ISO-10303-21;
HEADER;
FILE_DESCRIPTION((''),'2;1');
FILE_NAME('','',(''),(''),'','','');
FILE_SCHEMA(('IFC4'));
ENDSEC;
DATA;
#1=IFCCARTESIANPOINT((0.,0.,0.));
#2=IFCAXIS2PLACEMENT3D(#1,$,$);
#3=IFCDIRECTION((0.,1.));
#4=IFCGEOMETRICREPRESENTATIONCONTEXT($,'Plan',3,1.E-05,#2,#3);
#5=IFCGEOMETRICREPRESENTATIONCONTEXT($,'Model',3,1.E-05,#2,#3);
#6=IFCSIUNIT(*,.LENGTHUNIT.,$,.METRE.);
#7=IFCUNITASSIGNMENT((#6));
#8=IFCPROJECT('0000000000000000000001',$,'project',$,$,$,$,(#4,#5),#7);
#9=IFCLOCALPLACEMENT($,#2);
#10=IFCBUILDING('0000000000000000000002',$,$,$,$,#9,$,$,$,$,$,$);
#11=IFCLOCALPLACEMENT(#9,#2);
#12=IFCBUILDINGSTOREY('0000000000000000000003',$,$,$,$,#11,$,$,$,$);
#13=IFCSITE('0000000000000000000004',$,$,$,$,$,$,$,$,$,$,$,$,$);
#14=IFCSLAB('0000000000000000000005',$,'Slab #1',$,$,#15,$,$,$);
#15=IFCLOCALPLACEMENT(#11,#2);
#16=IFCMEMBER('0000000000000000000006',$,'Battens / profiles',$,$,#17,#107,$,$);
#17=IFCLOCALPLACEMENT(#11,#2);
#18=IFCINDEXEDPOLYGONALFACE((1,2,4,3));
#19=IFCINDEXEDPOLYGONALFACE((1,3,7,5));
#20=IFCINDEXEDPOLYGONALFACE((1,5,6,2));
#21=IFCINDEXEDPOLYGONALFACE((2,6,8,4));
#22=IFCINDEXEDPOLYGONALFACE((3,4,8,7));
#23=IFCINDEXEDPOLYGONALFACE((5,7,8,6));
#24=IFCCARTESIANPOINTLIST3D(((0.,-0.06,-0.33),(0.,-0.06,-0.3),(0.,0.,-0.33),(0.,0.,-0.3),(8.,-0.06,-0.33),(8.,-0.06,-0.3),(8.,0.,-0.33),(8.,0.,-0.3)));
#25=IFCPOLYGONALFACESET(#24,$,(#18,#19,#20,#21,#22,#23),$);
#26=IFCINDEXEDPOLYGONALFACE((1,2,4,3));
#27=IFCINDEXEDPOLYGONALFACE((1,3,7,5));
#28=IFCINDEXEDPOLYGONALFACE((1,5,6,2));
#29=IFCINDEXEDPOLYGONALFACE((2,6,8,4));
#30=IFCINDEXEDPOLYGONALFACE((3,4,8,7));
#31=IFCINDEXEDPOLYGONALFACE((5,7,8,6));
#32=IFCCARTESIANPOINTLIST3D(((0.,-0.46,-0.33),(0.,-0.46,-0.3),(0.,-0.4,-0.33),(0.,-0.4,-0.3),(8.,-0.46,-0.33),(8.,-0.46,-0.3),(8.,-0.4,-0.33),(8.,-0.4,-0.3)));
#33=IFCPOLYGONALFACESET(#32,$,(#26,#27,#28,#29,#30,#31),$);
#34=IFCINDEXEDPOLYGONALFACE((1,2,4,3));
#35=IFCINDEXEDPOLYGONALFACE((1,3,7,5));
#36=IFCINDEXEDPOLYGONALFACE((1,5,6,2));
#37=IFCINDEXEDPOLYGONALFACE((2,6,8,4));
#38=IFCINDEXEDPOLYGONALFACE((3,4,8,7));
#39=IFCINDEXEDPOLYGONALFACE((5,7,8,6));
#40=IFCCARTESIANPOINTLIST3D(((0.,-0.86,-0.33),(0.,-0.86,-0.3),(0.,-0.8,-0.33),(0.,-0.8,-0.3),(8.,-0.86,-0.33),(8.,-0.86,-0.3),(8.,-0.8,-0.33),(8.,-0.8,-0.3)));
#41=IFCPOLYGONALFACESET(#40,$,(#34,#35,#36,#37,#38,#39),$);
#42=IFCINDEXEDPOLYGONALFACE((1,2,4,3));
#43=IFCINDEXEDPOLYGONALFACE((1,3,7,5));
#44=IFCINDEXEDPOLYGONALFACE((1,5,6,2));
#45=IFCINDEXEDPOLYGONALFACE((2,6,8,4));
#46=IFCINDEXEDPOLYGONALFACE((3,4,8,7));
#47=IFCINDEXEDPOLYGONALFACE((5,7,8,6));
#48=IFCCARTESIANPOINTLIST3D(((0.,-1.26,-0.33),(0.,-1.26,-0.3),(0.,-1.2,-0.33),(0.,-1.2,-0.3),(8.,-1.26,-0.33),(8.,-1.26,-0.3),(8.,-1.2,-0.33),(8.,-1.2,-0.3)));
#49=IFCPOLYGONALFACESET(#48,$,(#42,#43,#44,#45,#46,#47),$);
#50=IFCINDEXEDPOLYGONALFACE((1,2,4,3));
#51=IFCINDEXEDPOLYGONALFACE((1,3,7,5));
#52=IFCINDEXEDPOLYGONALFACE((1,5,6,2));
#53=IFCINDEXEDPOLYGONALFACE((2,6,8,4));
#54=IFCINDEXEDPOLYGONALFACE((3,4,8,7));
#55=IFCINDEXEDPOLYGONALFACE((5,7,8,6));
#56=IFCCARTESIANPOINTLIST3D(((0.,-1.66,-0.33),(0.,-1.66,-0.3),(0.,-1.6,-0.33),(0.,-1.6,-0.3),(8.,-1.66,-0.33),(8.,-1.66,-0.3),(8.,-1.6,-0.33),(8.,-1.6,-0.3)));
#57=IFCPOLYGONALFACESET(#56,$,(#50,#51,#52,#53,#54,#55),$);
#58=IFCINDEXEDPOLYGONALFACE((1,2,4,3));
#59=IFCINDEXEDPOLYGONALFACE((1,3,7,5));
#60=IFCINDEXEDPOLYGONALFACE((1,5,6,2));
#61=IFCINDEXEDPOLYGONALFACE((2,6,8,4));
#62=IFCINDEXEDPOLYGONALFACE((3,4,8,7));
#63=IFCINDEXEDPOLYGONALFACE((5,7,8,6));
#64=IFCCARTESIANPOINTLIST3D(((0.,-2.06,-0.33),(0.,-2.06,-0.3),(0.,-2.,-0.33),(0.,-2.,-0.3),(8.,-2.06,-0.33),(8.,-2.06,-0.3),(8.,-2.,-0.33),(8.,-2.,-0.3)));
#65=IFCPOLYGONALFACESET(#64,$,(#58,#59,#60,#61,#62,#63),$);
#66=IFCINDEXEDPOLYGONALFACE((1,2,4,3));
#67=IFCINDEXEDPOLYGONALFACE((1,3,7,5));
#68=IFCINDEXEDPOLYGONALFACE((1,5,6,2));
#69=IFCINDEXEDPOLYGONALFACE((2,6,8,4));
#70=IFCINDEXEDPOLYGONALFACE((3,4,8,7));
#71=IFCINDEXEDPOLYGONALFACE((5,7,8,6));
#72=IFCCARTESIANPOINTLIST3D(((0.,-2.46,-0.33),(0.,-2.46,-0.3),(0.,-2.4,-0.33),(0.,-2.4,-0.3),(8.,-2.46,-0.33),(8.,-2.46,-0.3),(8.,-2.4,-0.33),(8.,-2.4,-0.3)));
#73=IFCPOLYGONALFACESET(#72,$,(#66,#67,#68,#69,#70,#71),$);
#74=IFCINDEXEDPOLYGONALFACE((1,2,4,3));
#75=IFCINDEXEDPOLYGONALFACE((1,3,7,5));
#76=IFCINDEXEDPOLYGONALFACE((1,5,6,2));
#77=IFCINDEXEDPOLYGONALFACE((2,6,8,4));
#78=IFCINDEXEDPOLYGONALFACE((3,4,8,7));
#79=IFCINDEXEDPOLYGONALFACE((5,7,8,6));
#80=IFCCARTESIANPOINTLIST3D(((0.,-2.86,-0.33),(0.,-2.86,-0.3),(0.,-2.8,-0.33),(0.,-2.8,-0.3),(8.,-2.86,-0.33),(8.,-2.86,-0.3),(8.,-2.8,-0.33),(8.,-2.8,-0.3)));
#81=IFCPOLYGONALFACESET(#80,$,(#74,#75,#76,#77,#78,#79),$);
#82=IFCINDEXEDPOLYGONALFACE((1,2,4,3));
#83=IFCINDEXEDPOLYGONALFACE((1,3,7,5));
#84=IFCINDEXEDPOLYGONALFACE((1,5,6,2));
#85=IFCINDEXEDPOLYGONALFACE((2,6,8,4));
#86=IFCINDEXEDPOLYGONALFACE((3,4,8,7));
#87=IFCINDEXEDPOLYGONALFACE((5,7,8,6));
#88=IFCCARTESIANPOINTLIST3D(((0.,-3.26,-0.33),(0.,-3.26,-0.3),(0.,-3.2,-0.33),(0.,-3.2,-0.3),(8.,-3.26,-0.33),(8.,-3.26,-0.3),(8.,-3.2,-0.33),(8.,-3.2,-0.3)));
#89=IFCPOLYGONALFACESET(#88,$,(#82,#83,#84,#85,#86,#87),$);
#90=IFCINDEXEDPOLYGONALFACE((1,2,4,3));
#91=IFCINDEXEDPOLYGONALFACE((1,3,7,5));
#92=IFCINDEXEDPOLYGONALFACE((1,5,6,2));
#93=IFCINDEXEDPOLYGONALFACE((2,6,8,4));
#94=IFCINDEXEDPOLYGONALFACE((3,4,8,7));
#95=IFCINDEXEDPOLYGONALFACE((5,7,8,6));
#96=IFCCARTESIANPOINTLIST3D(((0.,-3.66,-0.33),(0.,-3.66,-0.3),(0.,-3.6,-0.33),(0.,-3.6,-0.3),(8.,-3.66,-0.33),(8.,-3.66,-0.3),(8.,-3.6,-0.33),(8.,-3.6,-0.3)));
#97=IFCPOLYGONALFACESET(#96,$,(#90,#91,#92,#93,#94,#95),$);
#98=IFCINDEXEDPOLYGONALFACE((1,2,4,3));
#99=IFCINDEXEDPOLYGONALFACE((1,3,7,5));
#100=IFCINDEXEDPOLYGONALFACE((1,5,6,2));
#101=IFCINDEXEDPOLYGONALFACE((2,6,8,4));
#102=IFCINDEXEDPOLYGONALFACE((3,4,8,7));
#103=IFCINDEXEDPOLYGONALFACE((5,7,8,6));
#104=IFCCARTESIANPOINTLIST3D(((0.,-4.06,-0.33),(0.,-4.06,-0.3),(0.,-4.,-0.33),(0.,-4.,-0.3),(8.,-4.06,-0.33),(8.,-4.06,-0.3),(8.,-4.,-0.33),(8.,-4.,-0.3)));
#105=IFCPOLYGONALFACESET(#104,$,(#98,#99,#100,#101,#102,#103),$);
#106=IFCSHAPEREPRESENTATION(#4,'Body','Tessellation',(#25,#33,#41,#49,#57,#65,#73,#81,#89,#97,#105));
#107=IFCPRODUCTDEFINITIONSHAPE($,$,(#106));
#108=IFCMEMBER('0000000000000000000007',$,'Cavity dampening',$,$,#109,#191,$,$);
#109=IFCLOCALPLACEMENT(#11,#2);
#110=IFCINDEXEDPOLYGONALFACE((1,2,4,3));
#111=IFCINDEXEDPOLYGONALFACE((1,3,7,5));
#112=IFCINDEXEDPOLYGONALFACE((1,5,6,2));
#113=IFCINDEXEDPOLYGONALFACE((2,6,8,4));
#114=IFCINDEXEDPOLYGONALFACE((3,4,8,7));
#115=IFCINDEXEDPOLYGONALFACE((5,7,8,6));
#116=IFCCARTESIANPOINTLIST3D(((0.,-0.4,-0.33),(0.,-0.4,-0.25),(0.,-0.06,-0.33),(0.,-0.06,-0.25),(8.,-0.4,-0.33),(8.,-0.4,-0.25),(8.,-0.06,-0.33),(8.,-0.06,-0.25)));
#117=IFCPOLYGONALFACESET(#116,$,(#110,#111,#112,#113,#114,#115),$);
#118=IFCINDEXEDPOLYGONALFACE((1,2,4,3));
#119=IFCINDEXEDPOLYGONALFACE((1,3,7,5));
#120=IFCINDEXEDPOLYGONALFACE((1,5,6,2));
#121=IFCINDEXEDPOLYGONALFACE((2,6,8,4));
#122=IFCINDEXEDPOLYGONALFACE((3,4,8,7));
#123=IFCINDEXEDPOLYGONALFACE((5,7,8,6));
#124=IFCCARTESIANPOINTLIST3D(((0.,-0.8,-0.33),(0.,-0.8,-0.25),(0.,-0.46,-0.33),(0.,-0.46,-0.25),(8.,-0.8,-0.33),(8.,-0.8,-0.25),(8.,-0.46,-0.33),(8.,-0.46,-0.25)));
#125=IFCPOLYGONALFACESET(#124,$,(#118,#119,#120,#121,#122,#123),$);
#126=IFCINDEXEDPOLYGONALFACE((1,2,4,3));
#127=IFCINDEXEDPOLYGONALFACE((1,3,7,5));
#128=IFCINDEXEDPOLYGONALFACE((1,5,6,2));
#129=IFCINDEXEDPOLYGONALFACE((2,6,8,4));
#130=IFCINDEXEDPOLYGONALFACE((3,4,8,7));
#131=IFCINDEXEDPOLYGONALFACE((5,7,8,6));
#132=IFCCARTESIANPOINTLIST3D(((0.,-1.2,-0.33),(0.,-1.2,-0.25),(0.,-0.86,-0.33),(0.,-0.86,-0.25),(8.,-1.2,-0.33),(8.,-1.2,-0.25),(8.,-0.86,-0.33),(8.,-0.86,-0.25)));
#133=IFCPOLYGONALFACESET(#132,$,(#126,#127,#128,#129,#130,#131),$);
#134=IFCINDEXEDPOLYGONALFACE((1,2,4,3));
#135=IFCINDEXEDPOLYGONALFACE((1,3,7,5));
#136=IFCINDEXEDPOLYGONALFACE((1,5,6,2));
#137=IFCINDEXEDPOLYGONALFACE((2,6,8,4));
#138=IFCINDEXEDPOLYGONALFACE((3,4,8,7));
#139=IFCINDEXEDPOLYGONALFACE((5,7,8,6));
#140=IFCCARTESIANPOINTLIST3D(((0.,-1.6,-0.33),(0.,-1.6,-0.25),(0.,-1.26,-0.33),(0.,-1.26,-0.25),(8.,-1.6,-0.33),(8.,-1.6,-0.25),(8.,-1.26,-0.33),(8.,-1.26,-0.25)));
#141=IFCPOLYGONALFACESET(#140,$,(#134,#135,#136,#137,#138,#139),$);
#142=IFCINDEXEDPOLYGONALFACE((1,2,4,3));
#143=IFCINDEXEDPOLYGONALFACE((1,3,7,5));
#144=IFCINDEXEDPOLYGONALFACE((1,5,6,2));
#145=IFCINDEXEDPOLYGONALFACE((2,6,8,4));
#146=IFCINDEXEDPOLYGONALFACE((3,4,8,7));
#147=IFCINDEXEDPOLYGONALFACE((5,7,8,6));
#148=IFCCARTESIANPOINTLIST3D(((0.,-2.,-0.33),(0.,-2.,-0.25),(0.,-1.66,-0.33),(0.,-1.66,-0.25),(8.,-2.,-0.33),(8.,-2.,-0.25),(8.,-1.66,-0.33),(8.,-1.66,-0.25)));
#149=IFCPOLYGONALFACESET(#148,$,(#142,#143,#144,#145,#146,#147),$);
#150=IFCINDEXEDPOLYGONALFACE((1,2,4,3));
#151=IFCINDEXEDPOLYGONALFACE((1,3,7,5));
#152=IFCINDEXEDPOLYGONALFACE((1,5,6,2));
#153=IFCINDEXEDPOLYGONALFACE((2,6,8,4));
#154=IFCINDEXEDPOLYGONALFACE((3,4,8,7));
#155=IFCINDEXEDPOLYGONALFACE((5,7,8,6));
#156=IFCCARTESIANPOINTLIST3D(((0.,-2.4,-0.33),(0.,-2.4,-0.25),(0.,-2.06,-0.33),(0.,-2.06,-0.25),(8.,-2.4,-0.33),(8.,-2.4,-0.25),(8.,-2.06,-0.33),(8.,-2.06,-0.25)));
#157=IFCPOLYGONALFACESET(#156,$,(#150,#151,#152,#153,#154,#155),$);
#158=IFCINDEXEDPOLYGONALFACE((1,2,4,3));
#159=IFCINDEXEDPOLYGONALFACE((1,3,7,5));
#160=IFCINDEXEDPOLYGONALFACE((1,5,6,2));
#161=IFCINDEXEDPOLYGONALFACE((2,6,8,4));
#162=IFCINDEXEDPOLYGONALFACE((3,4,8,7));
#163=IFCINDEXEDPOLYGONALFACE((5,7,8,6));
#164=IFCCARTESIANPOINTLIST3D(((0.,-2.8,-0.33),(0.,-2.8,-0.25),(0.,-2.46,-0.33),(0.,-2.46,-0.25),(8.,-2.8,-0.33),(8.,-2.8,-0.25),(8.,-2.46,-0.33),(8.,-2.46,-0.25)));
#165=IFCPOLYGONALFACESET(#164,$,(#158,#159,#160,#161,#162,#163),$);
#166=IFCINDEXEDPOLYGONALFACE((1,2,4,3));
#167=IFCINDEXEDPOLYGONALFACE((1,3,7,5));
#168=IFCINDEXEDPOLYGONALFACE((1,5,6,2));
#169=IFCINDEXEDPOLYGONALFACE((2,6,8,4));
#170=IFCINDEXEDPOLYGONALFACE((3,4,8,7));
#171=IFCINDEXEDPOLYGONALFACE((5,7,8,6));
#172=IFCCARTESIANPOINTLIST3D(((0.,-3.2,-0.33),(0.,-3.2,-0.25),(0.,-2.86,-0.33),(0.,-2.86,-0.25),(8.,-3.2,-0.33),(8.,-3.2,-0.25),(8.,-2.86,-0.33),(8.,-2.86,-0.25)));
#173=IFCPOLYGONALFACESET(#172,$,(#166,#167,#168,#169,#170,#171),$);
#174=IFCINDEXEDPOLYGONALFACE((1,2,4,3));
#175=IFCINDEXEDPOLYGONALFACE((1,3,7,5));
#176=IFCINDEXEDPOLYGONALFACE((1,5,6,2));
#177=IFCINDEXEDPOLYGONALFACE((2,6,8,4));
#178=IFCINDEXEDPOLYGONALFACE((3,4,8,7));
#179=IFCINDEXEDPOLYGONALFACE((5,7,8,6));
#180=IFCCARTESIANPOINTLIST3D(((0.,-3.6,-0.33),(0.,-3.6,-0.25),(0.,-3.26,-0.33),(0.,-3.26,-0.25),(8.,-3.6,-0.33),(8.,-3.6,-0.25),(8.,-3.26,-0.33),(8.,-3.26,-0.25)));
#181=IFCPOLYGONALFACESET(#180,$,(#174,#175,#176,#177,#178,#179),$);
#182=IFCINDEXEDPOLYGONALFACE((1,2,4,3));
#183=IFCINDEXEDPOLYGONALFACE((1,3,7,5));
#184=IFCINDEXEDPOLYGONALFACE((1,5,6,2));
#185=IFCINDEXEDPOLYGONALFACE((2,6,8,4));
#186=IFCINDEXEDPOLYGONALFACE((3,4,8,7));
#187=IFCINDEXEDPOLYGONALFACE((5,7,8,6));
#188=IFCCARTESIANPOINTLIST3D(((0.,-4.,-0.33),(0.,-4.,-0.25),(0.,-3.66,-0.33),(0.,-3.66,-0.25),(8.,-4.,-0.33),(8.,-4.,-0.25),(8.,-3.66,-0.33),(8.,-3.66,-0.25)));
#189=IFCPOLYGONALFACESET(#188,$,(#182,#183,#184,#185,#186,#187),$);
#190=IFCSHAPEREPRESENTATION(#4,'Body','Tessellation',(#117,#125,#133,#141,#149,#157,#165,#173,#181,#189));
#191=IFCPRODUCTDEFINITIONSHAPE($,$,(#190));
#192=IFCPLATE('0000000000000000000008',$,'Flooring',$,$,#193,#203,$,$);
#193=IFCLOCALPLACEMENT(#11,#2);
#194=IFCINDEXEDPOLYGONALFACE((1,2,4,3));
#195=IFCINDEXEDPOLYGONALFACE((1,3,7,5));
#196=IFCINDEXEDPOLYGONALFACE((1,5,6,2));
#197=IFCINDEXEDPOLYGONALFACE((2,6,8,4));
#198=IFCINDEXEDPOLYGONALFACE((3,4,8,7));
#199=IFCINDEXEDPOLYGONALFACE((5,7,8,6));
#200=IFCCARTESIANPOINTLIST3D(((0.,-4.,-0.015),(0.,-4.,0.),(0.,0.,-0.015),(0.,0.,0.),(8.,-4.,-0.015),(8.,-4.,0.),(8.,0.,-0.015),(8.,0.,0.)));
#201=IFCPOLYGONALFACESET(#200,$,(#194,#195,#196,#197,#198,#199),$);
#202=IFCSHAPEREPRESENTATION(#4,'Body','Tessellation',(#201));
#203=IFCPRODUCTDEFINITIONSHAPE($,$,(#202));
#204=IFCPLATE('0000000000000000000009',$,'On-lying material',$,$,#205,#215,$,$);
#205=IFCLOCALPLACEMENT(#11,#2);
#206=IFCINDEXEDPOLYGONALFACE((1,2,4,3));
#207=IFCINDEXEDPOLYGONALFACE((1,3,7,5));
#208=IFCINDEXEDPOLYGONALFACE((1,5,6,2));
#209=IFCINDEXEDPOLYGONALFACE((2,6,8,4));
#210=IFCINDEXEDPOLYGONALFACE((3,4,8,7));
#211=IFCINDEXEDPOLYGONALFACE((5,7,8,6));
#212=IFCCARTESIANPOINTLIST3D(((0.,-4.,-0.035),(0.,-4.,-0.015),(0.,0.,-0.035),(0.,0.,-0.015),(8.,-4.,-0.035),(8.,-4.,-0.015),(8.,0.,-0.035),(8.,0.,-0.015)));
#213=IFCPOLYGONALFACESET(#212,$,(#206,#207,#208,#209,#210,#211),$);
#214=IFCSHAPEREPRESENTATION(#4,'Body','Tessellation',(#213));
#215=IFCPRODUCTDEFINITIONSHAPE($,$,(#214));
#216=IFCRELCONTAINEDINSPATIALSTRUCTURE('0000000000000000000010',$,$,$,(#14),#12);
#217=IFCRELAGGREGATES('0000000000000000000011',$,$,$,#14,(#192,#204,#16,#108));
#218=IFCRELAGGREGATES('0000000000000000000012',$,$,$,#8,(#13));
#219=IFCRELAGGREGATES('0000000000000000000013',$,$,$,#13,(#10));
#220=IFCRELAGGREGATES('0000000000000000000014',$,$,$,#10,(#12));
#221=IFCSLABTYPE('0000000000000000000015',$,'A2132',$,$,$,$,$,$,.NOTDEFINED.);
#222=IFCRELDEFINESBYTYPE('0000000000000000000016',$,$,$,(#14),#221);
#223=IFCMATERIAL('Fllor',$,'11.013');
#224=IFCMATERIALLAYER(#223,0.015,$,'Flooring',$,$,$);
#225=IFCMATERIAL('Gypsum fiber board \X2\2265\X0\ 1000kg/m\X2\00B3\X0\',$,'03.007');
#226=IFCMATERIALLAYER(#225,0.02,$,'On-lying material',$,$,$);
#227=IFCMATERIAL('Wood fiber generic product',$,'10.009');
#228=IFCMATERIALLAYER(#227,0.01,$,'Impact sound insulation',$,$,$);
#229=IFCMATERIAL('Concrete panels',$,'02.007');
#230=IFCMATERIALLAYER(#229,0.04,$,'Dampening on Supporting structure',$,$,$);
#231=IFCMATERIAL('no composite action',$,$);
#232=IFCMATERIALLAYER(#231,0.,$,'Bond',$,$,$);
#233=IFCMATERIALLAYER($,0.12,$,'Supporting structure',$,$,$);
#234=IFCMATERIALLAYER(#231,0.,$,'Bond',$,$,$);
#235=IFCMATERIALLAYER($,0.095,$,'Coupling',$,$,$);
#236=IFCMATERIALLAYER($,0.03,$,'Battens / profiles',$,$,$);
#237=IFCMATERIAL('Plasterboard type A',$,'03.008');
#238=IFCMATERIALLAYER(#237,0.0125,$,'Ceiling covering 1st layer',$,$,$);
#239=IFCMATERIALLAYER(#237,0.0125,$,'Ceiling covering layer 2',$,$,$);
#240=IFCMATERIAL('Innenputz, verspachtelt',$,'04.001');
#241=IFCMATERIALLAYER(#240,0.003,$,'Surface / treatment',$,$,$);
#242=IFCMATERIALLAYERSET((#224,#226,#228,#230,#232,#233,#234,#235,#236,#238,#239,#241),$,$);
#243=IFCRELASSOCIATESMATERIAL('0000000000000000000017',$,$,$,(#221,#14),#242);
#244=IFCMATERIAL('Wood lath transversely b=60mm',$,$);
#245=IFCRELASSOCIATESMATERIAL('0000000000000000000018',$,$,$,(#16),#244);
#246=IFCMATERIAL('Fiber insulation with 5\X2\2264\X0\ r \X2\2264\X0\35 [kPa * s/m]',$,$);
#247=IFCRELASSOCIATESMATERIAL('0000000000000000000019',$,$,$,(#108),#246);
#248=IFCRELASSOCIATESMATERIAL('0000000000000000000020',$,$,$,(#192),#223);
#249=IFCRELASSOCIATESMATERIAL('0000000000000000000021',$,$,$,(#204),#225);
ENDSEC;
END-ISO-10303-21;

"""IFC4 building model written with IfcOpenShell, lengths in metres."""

from ifc_helpers import new_model, si_unit, direction, frame, frame_2d, origin, origin_with_axes, place, context, project, spatial, rectangle, extrude, material, layer, layer_set, type_object, element, aggregate, save


model = new_model("IFC4")

# Units and contexts
plan_context = context("Plan", 3, precision=1e-05, world=origin(), true_north=direction((0.0, 1.0)))
model_context = context("Model", 3, precision=1e-05, world=origin(), true_north=direction((0.0, 1.0)))
ifc_project = project(units=[si_unit("LENGTHUNIT", "METRE")], contexts=[plan_context, model_context])

# Site, building, storey
site = spatial("IfcSite", under=ifc_project)
building_placement = place(None, origin())
building = spatial("IfcBuilding", under=site, at=building_placement)
storey_placement = place(building_placement, origin())
storey = spatial("IfcBuildingStorey", under=building, at=storey_placement)

# Slab, members, plates
ifc_material_1 = material(Name="Fllor", Category="11.013")
ifc_layer_1 = layer(ifc_material_1, 0.015, Name="Flooring")
ifc_material_2 = material(Name="Gypsum fiber board ≥ 1000kg/m³", Category="03.007")
ifc_layer_2 = layer(ifc_material_2, 0.02, Name="On-lying material")
ifc_material_3 = material(Name="Wood fiber generic product", Category="10.009")
ifc_layer_3 = layer(ifc_material_3, 0.01, Name="Impact sound insulation")
ifc_material_4 = material(Name="Concrete panels", Category="02.007")
ifc_layer_4 = layer(ifc_material_4, 0.04, Name="Dampening on Supporting structure")
ifc_material_5 = material(Name="no composite action")
ifc_layer_5 = layer(ifc_material_5, 0.0, Name="Bond")
ifc_layer_6 = layer(None, 0.12, Name="Supporting structure")
ifc_layer_7 = layer(ifc_material_5, 0.0, Name="Bond")
ifc_layer_8 = layer(None, 0.095, Name="Coupling")
ifc_layer_9 = layer(None, 0.03, Name="Battens / profiles")
ifc_material_6 = material(Name="Plasterboard type A", Category="03.008")
ifc_layer_10 = layer(ifc_material_6, 0.0125, Name="Ceiling covering 1st layer")
ifc_layer_11 = layer(ifc_material_6, 0.0125, Name="Ceiling covering layer 2")
ifc_material_7 = material(Name="Innenputz, verspachtelt", Category="04.001")
ifc_layer_12 = layer(ifc_material_7, 0.003, Name="Surface / treatment")
ifc_layer_set = layer_set([ifc_layer_1, ifc_layer_2, ifc_layer_3, ifc_layer_4, ifc_layer_5, ifc_layer_6, ifc_layer_7, ifc_layer_8, ifc_layer_9, ifc_layer_10, ifc_layer_11, ifc_layer_12])
slab_type = type_object("IfcSlabType", Name="A2132", PredefinedType="NOTDEFINED", material=ifc_layer_set)
slab_placement = place(None, frame((0.0, 0.0, 0.0), z_axis=(0.0, 0.0, -1.0), x_axis=(1.0, 0.0, 0.0)))
slab = element("IfcSlab", 1, at=slab_placement, inside=storey, type_object=slab_type, material=ifc_layer_set, Name="Slab #1")
ifc_material_8 = material(Name="Wood lath transversely b=60mm")
member_1_placement = place(slab_placement, origin())
member_1 = element("IfcMember", 2, at=member_1_placement, material=ifc_material_8, Name="Battens / profiles", context=plan_context, shape_type="SweptSolid", body=[
    extrude(rectangle(XDim=0.06, YDim=0.03, at=frame_2d((0.03, 0.015), x_axis=(1.0, 0.0))), frame((0.0, 0.0, 0.3), z_axis=(1.0, 0.0, 0.0), x_axis=(0.0, 1.0, 0.0)), (0.0, 0.0, 1.0), 8.0),
    extrude(rectangle(XDim=0.06, YDim=0.03, at=frame_2d((0.03, 0.015), x_axis=(1.0, 0.0))), frame((0.0, 0.4, 0.3), z_axis=(1.0, 0.0, 0.0), x_axis=(0.0, 1.0, 0.0)), (0.0, 0.0, 1.0), 8.0),
    extrude(rectangle(XDim=0.06, YDim=0.03, at=frame_2d((0.03, 0.015), x_axis=(1.0, 0.0))), frame((0.0, 0.8, 0.3), z_axis=(1.0, 0.0, 0.0), x_axis=(0.0, 1.0, 0.0)), (0.0, 0.0, 1.0), 8.0),
    extrude(rectangle(XDim=0.06, YDim=0.03, at=frame_2d((0.03, 0.015), x_axis=(1.0, 0.0))), frame((0.0, 1.2, 0.3), z_axis=(1.0, 0.0, 0.0), x_axis=(0.0, 1.0, 0.0)), (0.0, 0.0, 1.0), 8.0),
    extrude(rectangle(XDim=0.06, YDim=0.03, at=frame_2d((0.03, 0.015), x_axis=(1.0, 0.0))), frame((0.0, 1.6, 0.3), z_axis=(1.0, 0.0, 0.0), x_axis=(0.0, 1.0, 0.0)), (0.0, 0.0, 1.0), 8.0),
    extrude(rectangle(XDim=0.06, YDim=0.03, at=frame_2d((0.03, 0.015), x_axis=(1.0, 0.0))), frame((0.0, 2.0, 0.3), z_axis=(1.0, 0.0, 0.0), x_axis=(0.0, 1.0, 0.0)), (0.0, 0.0, 1.0), 8.0),
    extrude(rectangle(XDim=0.06, YDim=0.03, at=frame_2d((0.03, 0.015), x_axis=(1.0, 0.0))), frame((0.0, 2.4, 0.3), z_axis=(1.0, 0.0, 0.0), x_axis=(0.0, 1.0, 0.0)), (0.0, 0.0, 1.0), 8.0),
    extrude(rectangle(XDim=0.06, YDim=0.03, at=frame_2d((0.03, 0.015), x_axis=(1.0, 0.0))), frame((0.0, 2.8, 0.3), z_axis=(1.0, 0.0, 0.0), x_axis=(0.0, 1.0, 0.0)), (0.0, 0.0, 1.0), 8.0),
    extrude(rectangle(XDim=0.06, YDim=0.03, at=frame_2d((0.03, 0.015), x_axis=(1.0, 0.0))), frame((0.0, 3.2, 0.3), z_axis=(1.0, 0.0, 0.0), x_axis=(0.0, 1.0, 0.0)), (0.0, 0.0, 1.0), 8.0),
    extrude(rectangle(XDim=0.06, YDim=0.03, at=frame_2d((0.03, 0.015), x_axis=(1.0, 0.0))), frame((0.0, 3.6, 0.3), z_axis=(1.0, 0.0, 0.0), x_axis=(0.0, 1.0, 0.0)), (0.0, 0.0, 1.0), 8.0),
    extrude(rectangle(XDim=0.06, YDim=0.03, at=frame_2d((0.03, 0.015), x_axis=(1.0, 0.0))), frame((0.0, 4.0, 0.3), z_axis=(1.0, 0.0, 0.0), x_axis=(0.0, 1.0, 0.0)), (0.0, 0.0, 1.0), 8.0),
])
ifc_material_9 = material(Name="Fiber insulation with 5≤ r ≤35 [kPa * s/m]")
member_2_placement = place(slab_placement, origin())
member_2 = element("IfcMember", 3, at=member_2_placement, material=ifc_material_9, Name="Cavity dampening", context=plan_context, shape_type="SweptSolid", body=[
    extrude(rectangle(XDim=0.34, YDim=0.08, at=frame_2d((0.17, 0.04), x_axis=(1.0, 0.0))), frame((0.0, 0.06, 0.25), z_axis=(1.0, 0.0, 0.0), x_axis=(0.0, 1.0, 0.0)), (0.0, 0.0, 1.0), 8.0),
    extrude(rectangle(XDim=0.34, YDim=0.08, at=frame_2d((0.17, 0.04), x_axis=(1.0, 0.0))), frame((0.0, 0.46, 0.25), z_axis=(1.0, 0.0, 0.0), x_axis=(0.0, 1.0, 0.0)), (0.0, 0.0, 1.0), 8.0),
    extrude(rectangle(XDim=0.34, YDim=0.08, at=frame_2d((0.17, 0.04), x_axis=(1.0, 0.0))), frame((0.0, 0.86, 0.25), z_axis=(1.0, 0.0, 0.0), x_axis=(0.0, 1.0, 0.0)), (0.0, 0.0, 1.0), 8.0),
    extrude(rectangle(XDim=0.34, YDim=0.08, at=frame_2d((0.17, 0.04), x_axis=(1.0, 0.0))), frame((0.0, 1.26, 0.25), z_axis=(1.0, 0.0, 0.0), x_axis=(0.0, 1.0, 0.0)), (0.0, 0.0, 1.0), 8.0),
    extrude(rectangle(XDim=0.34, YDim=0.08, at=frame_2d((0.17, 0.04), x_axis=(1.0, 0.0))), frame((0.0, 1.66, 0.25), z_axis=(1.0, 0.0, 0.0), x_axis=(0.0, 1.0, 0.0)), (0.0, 0.0, 1.0), 8.0),
    extrude(rectangle(XDim=0.34, YDim=0.08, at=frame_2d((0.17, 0.04), x_axis=(1.0, 0.0))), frame((0.0, 2.06, 0.25), z_axis=(1.0, 0.0, 0.0), x_axis=(0.0, 1.0, 0.0)), (0.0, 0.0, 1.0), 8.0),
    extrude(rectangle(XDim=0.34, YDim=0.08, at=frame_2d((0.17, 0.04), x_axis=(1.0, 0.0))), frame((0.0, 2.46, 0.25), z_axis=(1.0, 0.0, 0.0), x_axis=(0.0, 1.0, 0.0)), (0.0, 0.0, 1.0), 8.0),
    extrude(rectangle(XDim=0.34, YDim=0.08, at=frame_2d((0.17, 0.04), x_axis=(1.0, 0.0))), frame((0.0, 2.86, 0.25), z_axis=(1.0, 0.0, 0.0), x_axis=(0.0, 1.0, 0.0)), (0.0, 0.0, 1.0), 8.0),
    extrude(rectangle(XDim=0.34, YDim=0.08, at=frame_2d((0.17, 0.04), x_axis=(1.0, 0.0))), frame((0.0, 3.26, 0.25), z_axis=(1.0, 0.0, 0.0), x_axis=(0.0, 1.0, 0.0)), (0.0, 0.0, 1.0), 8.0),
    extrude(rectangle(XDim=0.34, YDim=0.08, at=frame_2d((0.17, 0.04), x_axis=(1.0, 0.0))), frame((0.0, 3.66, 0.25), z_axis=(1.0, 0.0, 0.0), x_axis=(0.0, 1.0, 0.0)), (0.0, 0.0, 1.0), 8.0),
])
plate_1_placement = place(slab_placement, origin())
plate_1 = element("IfcPlate", 4, at=plate_1_placement, material=ifc_material_1, Name="Flooring", context=plan_context, shape_type="SweptSolid", body=[
    extrude(rectangle(XDim=8.0, YDim=4.0, at=frame_2d((4.0, 2.0), x_axis=(1.0, 0.0))), origin_with_axes(), (0.0, 0.0, 1.0), 0.015),
])
plate_2_placement = place(slab_placement, origin())
plate_2 = element("IfcPlate", 5, at=plate_2_placement, material=ifc_material_2, Name="On-lying material", context=plan_context, shape_type="SweptSolid", body=[
    extrude(rectangle(XDim=8.0, YDim=4.0, at=frame_2d((4.0, 2.0), x_axis=(1.0, 0.0))), frame((0.0, 0.0, 0.015), z_axis=(0.0, 0.0, 1.0), x_axis=(1.0, 0.0, 0.0)), (0.0, 0.0, 1.0), 0.02),
])
aggregate(slab, [plate_1, plate_2, member_1, member_2])

save(model, "model.ifc")
